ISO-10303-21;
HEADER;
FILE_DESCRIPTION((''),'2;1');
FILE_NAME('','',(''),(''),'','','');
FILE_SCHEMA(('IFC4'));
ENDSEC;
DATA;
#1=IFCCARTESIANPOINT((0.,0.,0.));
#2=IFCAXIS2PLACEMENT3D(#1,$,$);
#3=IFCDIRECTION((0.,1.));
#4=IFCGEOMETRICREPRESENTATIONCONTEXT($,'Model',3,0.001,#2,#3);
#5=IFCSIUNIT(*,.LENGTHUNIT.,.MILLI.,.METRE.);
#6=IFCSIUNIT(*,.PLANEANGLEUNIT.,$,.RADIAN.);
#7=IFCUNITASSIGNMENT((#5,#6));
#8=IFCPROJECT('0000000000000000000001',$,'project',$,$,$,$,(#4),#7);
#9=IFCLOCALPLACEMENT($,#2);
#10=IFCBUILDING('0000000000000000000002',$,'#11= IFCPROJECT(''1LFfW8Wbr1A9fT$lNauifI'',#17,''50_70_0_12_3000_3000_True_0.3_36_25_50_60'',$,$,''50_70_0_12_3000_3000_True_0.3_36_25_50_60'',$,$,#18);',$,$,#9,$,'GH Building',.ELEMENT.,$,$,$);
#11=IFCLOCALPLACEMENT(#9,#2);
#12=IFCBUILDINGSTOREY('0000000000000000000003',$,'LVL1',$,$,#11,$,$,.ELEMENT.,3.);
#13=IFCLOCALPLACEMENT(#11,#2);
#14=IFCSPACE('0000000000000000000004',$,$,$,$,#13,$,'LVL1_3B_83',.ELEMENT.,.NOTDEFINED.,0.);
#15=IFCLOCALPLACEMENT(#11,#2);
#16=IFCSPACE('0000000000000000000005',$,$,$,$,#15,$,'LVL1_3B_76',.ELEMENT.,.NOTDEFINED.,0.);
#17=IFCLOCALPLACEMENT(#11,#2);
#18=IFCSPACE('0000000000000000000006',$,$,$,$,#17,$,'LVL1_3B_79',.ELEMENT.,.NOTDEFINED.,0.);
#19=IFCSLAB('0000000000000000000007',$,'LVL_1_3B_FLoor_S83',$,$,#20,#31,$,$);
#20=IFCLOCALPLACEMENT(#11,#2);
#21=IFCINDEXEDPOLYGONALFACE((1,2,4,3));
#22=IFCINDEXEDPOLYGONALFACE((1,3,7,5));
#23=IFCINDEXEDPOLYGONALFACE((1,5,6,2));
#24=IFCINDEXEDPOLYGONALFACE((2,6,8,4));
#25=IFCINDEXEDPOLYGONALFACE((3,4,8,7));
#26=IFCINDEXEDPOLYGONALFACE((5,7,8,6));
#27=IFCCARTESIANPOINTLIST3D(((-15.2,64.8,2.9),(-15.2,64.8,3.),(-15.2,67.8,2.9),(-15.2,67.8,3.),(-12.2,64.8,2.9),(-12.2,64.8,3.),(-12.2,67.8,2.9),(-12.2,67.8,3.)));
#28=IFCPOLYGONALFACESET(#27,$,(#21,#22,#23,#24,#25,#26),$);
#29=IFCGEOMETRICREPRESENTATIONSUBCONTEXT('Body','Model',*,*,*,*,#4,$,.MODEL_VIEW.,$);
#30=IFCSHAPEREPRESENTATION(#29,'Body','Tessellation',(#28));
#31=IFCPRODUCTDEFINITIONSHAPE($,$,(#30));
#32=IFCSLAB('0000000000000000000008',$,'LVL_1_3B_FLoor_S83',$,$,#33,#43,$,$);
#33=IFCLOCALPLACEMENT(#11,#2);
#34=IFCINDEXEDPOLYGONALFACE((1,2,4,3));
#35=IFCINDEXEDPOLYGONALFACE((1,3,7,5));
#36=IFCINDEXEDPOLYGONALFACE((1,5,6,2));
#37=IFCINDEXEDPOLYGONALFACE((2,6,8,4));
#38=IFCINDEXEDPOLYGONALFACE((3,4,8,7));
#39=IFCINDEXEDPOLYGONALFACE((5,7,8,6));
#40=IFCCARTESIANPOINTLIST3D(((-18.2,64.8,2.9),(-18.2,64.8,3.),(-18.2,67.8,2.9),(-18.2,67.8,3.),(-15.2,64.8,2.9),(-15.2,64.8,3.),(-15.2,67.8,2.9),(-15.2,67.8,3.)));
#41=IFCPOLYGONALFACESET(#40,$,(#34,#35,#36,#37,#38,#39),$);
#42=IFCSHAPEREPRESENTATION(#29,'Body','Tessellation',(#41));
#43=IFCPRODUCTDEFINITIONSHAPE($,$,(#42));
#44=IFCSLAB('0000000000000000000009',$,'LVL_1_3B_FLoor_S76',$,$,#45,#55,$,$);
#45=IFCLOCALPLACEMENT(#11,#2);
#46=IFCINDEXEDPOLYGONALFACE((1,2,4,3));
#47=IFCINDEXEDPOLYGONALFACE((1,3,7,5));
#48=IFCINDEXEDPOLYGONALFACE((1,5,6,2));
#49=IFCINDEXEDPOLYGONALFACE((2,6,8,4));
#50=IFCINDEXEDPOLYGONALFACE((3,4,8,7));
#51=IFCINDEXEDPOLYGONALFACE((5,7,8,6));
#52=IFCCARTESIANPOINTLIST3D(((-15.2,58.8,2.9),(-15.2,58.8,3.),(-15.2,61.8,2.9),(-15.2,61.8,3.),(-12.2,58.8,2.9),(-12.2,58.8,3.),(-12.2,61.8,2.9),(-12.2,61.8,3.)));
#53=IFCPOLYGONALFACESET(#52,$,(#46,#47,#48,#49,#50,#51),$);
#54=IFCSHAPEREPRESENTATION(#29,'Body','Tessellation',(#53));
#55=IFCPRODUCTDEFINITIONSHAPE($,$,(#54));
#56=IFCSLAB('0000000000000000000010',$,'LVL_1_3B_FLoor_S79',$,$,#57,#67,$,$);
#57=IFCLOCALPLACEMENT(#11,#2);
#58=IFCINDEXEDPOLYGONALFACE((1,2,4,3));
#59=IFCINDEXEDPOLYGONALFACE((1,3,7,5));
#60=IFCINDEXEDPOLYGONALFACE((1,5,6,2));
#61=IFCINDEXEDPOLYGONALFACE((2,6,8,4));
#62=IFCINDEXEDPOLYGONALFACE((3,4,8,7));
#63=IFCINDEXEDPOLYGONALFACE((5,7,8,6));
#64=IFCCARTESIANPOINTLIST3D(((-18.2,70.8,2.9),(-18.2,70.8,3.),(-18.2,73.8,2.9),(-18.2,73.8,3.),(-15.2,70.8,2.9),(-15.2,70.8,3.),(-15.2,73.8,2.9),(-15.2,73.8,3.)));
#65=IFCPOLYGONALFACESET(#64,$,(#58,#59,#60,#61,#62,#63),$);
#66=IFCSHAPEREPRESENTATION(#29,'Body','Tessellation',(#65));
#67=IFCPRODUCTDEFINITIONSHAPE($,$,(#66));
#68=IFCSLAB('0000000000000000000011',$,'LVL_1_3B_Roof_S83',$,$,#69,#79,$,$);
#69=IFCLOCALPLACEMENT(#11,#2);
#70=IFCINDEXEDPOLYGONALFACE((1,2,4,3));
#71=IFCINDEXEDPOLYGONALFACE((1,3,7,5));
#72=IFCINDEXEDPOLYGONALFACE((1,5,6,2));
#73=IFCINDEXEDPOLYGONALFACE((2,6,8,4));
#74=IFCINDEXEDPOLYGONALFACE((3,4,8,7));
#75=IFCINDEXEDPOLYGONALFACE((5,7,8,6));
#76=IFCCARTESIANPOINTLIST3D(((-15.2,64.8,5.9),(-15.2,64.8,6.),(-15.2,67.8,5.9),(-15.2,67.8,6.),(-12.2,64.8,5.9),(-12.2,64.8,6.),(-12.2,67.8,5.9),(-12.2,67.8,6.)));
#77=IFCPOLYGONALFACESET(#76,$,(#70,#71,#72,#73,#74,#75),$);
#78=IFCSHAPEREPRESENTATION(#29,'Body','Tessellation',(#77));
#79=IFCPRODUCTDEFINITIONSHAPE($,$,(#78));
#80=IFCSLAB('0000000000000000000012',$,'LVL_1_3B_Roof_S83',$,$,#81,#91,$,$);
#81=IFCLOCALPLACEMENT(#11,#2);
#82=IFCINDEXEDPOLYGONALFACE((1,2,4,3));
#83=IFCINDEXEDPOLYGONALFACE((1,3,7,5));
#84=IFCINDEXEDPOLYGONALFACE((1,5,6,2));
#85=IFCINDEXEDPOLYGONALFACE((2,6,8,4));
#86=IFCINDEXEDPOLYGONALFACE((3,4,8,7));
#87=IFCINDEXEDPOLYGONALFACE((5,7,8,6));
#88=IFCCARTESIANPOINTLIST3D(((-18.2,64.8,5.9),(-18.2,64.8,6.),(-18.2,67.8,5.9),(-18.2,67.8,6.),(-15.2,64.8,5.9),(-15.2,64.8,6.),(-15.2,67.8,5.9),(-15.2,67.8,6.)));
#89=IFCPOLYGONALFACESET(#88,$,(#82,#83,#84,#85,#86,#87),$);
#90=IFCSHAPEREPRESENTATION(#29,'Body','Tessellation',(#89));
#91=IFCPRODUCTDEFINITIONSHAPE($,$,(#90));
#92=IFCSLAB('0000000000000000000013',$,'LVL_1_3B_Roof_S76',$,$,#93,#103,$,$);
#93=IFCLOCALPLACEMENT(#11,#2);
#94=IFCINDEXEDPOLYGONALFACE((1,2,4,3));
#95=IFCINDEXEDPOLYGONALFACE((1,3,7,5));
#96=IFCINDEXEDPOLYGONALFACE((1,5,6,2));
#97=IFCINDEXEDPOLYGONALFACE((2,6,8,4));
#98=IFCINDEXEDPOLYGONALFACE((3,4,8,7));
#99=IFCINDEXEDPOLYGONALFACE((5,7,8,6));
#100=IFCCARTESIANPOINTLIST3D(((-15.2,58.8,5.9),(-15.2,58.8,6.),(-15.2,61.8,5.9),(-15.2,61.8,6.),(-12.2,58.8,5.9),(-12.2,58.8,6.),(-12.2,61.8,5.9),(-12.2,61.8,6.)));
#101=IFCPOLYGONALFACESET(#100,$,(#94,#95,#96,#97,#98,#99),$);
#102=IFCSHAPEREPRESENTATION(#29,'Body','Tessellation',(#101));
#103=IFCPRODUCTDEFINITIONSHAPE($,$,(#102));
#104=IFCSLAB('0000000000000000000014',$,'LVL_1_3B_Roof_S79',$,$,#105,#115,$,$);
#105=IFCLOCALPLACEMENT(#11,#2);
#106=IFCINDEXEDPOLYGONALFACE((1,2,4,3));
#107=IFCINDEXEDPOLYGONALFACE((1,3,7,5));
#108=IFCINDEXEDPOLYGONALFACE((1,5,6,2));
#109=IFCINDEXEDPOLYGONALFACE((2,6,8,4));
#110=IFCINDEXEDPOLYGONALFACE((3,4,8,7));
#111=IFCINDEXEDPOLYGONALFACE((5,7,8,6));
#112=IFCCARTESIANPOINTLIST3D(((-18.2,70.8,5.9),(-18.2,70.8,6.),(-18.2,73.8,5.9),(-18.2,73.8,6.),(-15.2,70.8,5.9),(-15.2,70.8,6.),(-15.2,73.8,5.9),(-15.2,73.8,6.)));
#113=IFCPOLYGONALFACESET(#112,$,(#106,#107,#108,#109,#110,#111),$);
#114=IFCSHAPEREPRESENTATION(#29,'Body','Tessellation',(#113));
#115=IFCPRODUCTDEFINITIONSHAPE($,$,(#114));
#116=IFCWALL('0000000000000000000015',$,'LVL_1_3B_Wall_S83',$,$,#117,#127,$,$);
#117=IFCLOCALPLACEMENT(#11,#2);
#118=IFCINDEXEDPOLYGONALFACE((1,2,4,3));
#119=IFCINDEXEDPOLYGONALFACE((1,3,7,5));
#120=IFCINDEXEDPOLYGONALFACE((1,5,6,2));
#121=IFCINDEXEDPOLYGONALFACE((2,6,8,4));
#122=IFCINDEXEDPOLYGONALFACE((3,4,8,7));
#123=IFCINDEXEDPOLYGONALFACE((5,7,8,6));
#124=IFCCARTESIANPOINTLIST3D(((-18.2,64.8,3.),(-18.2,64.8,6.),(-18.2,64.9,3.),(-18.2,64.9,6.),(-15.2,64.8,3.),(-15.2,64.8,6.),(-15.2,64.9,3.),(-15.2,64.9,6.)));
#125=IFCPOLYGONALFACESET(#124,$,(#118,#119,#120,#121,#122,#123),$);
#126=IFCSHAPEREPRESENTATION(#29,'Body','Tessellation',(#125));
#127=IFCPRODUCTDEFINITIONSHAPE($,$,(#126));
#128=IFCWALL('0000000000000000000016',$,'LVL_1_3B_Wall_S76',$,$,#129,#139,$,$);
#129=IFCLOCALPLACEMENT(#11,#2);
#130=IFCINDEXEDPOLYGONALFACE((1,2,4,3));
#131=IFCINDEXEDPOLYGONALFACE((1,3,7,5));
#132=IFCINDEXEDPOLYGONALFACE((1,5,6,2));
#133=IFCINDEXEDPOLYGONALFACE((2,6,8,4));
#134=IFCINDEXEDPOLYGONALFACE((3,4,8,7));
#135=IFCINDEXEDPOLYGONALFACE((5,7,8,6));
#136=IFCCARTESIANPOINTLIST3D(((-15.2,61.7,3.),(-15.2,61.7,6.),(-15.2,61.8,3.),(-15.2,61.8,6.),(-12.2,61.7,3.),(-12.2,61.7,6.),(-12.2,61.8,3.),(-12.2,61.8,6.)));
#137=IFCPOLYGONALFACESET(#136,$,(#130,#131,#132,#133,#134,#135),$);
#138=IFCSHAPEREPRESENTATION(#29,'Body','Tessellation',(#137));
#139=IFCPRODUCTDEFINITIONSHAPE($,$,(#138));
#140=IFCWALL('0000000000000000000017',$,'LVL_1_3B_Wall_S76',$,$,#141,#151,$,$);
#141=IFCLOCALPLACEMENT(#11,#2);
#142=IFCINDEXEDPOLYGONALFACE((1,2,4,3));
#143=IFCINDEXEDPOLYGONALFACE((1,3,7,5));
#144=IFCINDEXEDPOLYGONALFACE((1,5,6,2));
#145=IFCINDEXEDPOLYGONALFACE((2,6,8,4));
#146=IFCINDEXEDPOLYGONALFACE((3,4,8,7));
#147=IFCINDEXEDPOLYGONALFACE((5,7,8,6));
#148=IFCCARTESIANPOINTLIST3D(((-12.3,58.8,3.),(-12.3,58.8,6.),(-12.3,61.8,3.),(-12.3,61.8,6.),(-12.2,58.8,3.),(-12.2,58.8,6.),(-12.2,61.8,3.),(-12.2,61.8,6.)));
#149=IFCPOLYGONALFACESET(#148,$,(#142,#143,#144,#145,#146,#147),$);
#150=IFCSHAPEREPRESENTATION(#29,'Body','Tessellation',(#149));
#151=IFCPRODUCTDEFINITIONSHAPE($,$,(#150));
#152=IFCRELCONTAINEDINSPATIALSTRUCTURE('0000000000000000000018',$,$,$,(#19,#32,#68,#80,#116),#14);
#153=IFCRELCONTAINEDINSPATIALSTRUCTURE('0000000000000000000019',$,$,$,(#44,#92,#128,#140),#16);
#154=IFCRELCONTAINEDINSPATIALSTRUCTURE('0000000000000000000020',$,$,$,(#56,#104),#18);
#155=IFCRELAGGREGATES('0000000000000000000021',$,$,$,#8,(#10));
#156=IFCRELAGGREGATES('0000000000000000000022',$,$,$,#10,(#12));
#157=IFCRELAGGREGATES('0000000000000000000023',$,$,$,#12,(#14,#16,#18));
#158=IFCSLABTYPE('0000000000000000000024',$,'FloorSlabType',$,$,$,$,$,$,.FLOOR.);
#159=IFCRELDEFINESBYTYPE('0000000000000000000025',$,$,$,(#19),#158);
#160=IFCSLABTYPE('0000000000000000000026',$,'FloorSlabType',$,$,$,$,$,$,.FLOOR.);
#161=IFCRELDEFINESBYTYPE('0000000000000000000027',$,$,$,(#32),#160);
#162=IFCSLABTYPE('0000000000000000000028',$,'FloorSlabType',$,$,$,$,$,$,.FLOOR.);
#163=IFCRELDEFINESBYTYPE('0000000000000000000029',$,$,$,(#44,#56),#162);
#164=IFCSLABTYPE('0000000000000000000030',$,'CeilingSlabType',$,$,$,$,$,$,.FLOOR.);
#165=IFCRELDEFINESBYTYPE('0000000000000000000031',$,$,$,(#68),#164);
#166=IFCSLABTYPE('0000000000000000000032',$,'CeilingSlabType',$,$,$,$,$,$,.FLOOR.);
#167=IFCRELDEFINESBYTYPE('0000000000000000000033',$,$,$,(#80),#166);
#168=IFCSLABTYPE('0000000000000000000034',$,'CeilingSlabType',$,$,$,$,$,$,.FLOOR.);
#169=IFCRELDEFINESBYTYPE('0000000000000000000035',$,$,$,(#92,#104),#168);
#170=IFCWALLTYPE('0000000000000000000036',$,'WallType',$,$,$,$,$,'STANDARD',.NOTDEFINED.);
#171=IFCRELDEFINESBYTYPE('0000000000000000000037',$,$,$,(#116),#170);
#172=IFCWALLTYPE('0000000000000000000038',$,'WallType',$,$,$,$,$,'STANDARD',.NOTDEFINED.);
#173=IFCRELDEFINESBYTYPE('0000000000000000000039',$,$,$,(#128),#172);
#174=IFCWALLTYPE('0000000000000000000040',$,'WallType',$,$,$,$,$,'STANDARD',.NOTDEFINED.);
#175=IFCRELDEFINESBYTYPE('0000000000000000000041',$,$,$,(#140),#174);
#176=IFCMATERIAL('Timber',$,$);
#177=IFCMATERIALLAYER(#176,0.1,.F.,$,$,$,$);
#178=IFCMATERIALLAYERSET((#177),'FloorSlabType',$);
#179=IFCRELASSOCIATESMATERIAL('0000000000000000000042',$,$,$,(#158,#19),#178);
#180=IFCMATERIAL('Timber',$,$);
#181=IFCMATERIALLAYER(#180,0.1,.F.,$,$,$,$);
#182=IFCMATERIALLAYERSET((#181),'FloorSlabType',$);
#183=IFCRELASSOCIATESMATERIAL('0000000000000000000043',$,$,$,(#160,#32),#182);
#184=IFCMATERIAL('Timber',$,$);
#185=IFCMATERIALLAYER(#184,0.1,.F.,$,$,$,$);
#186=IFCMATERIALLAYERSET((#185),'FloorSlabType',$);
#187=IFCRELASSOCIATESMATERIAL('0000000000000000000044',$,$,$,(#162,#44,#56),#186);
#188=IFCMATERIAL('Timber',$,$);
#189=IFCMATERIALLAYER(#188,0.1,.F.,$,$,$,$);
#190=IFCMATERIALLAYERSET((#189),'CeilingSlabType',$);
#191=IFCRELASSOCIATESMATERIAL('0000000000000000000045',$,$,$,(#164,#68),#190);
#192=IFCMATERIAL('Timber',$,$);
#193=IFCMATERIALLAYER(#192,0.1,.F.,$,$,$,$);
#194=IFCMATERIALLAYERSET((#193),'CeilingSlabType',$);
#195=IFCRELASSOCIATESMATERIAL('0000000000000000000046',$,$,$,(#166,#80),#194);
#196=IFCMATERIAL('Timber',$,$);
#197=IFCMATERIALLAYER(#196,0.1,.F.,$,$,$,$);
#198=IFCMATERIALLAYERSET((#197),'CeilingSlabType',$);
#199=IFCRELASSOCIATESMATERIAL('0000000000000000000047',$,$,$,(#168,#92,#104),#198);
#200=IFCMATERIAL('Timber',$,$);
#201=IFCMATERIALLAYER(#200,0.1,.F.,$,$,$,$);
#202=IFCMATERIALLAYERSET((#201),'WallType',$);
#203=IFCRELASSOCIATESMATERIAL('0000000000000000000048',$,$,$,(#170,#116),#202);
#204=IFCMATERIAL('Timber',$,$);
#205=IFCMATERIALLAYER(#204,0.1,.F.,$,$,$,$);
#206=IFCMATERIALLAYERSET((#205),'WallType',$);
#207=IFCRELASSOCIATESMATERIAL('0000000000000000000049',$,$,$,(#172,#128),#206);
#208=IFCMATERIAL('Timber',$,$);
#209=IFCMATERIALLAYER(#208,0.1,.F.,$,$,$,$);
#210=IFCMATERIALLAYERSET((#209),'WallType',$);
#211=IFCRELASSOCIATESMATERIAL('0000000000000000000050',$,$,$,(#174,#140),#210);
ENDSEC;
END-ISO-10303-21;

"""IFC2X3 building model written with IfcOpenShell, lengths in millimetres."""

from ifc_helpers import new_model, si_unit, direction, frame, frame_2d, origin, place, context, subcontext, project, spatial, rectangle, extrude, material, layer, layer_set, layer_usage, type_object, element, save


model = new_model("IFC2X3")

# Units and contexts
model_context = context("Model", 3, precision=0.001, world=origin(), true_north=direction((0.0, 1.0)))
body_context = subcontext(model_context, "Body", "Model", "MODEL_VIEW")
ifc_project = project(units=[si_unit("LENGTHUNIT", "METRE", prefix="MILLI"), si_unit("PLANEANGLEUNIT", "RADIAN")], contexts=[model_context])

# Building, storey
building_placement = place(None, origin())
building = spatial("IfcBuilding", under=ifc_project, at=building_placement, Name="#11= IFCPROJECT('1LFfW8Wbr1A9fT$lNauifI',#17,'50_70_0_12_3000_3000_True_0.3_36_25_50_60',$,$,'50_70_0_12_3000_3000_True_0.3_36_25_50_60',$,$,#18);", LongName="GH Building", CompositionType="ELEMENT")
storey_placement = place(building_placement, origin())
storey = spatial("IfcBuildingStorey", under=building, at=storey_placement, Name="LVL1", CompositionType="ELEMENT", Elevation=3.0)

# Shared definitions
space_1_placement = place(storey_placement, origin())
space_1 = spatial("IfcSpace", under=storey, at=space_1_placement, LongName="LVL1_3B_83", CompositionType="ELEMENT", InteriorOrExteriorSpace="NOTDEFINED", ElevationWithFlooring=0.0)

# Slabs
ifc_material_1 = material(Name="Timber")
ifc_layer_1 = layer(ifc_material_1, 0.1, ventilated=False)
ifc_layer_set_1 = layer_set([ifc_layer_1], Name="FloorSlabType")
ifc_layer_usage_1 = layer_usage(ifc_layer_set_1, "AXIS3", "NEGATIVE", -0.1)
slab_type_1 = type_object("IfcSlabType", Name="FloorSlabType", PredefinedType="FLOOR", material=ifc_layer_set_1)
slab_1_placement = place(space_1_placement, frame((-12.2, 67.8, 2.9), z_axis=(0.0, 0.0, 1.0), x_axis=(-1.0, 0.0, 0.0)))
element("IfcSlab", 1, at=slab_1_placement, inside=space_1, type_object=slab_type_1, material=ifc_layer_usage_1, Name="LVL_1_3B_FLoor_S83", context=body_context, shape_type="SweptSolid", body=[
    extrude(rectangle(XDim=3.0, YDim=3.0, at=frame_2d((1.5, 1.5))), origin(), (0.0, 0.0, 1.0), 0.1),
])
ifc_material_2 = material(Name="Timber")
ifc_layer_2 = layer(ifc_material_2, 0.1, ventilated=False)
ifc_layer_set_2 = layer_set([ifc_layer_2], Name="FloorSlabType")
ifc_layer_usage_2 = layer_usage(ifc_layer_set_2, "AXIS3", "NEGATIVE", -0.1)
slab_type_2 = type_object("IfcSlabType", Name="FloorSlabType", PredefinedType="FLOOR", material=ifc_layer_set_2)
slab_2_placement = place(space_1_placement, frame((-15.2, 67.8, 2.9), z_axis=(0.0, 0.0, 1.0), x_axis=(-1.0, 0.0, 0.0)))
element("IfcSlab", 2, at=slab_2_placement, inside=space_1, type_object=slab_type_2, material=ifc_layer_usage_2, Name="LVL_1_3B_FLoor_S83", context=body_context, shape_type="SweptSolid", body=[
    extrude(rectangle(XDim=3.0, YDim=3.0, at=frame_2d((1.5, 1.5))), origin(), (0.0, 0.0, 1.0), 0.1),
])

# Shared definitions
space_2_placement = place(storey_placement, origin())
space_2 = spatial("IfcSpace", under=storey, at=space_2_placement, LongName="LVL1_3B_76", CompositionType="ELEMENT", InteriorOrExteriorSpace="NOTDEFINED", ElevationWithFlooring=0.0)

# Slab
ifc_material_3 = material(Name="Timber")
ifc_layer_3 = layer(ifc_material_3, 0.1, ventilated=False)
ifc_layer_set_3 = layer_set([ifc_layer_3], Name="FloorSlabType")
ifc_layer_usage_3 = layer_usage(ifc_layer_set_3, "AXIS3", "NEGATIVE", -0.1)
slab_type_3 = type_object("IfcSlabType", Name="FloorSlabType", PredefinedType="FLOOR", material=ifc_layer_set_3)
slab_3_placement = place(space_2_placement, frame((-15.2, 61.8, 2.9), z_axis=(0.0, 0.0, 1.0), x_axis=(0.0, -1.0, 0.0)))
element("IfcSlab", 3, at=slab_3_placement, inside=space_2, type_object=slab_type_3, material=ifc_layer_usage_3, Name="LVL_1_3B_FLoor_S76", context=body_context, shape_type="SweptSolid", body=[
    extrude(rectangle(XDim=3.0, YDim=3.0, at=frame_2d((1.5, 1.5))), origin(), (0.0, 0.0, 1.0), 0.1),
])

# Shared definitions
space_3_placement = place(storey_placement, origin())
space_3 = spatial("IfcSpace", under=storey, at=space_3_placement, LongName="LVL1_3B_79", CompositionType="ELEMENT", InteriorOrExteriorSpace="NOTDEFINED", ElevationWithFlooring=0.0)

# Slabs
ifc_layer_usage_4 = layer_usage(ifc_layer_set_3, "AXIS3", "NEGATIVE", -0.1)
slab_4_placement = place(space_3_placement, frame((-15.2, 73.8, 2.9), z_axis=(0.0, 0.0, 1.0), x_axis=(-1.0, 0.0, 0.0)))
element("IfcSlab", 4, at=slab_4_placement, inside=space_3, type_object=slab_type_3, material=ifc_layer_usage_4, Name="LVL_1_3B_FLoor_S79", context=body_context, shape_type="SweptSolid", body=[
    extrude(rectangle(XDim=3.0, YDim=3.0, at=frame_2d((1.5, 1.5))), origin(), (0.0, 0.0, 1.0), 0.1),
])
ifc_material_4 = material(Name="Timber")
ifc_layer_4 = layer(ifc_material_4, 0.1, ventilated=False)
ifc_layer_set_4 = layer_set([ifc_layer_4], Name="CeilingSlabType")
ifc_layer_usage_5 = layer_usage(ifc_layer_set_4, "AXIS3", "NEGATIVE", -0.1)
slab_type_4 = type_object("IfcSlabType", Name="CeilingSlabType", PredefinedType="FLOOR", material=ifc_layer_set_4)
slab_5_placement = place(space_1_placement, frame((-12.2, 67.8, 5.9), z_axis=(0.0, 0.0, 1.0), x_axis=(-1.0, 0.0, 0.0)))
element("IfcSlab", 5, at=slab_5_placement, inside=space_1, type_object=slab_type_4, material=ifc_layer_usage_5, Name="LVL_1_3B_Roof_S83", context=body_context, shape_type="SweptSolid", body=[
    extrude(rectangle(XDim=3.0, YDim=3.0, at=frame_2d((1.5, 1.5))), origin(), (0.0, 0.0, 1.0), 0.1),
])
ifc_material_5 = material(Name="Timber")
ifc_layer_5 = layer(ifc_material_5, 0.1, ventilated=False)
ifc_layer_set_5 = layer_set([ifc_layer_5], Name="CeilingSlabType")
ifc_layer_usage_6 = layer_usage(ifc_layer_set_5, "AXIS3", "NEGATIVE", -0.1)
slab_type_5 = type_object("IfcSlabType", Name="CeilingSlabType", PredefinedType="FLOOR", material=ifc_layer_set_5)
slab_6_placement = place(space_1_placement, frame((-15.2, 67.8, 5.9), z_axis=(0.0, 0.0, 1.0), x_axis=(-1.0, 0.0, 0.0)))
element("IfcSlab", 6, at=slab_6_placement, inside=space_1, type_object=slab_type_5, material=ifc_layer_usage_6, Name="LVL_1_3B_Roof_S83", context=body_context, shape_type="SweptSolid", body=[
    extrude(rectangle(XDim=3.0, YDim=3.0, at=frame_2d((1.5, 1.5))), origin(), (0.0, 0.0, 1.0), 0.1),
])
ifc_material_6 = material(Name="Timber")
ifc_layer_6 = layer(ifc_material_6, 0.1, ventilated=False)
ifc_layer_set_6 = layer_set([ifc_layer_6], Name="CeilingSlabType")
ifc_layer_usage_7 = layer_usage(ifc_layer_set_6, "AXIS3", "NEGATIVE", -0.1)
slab_type_6 = type_object("IfcSlabType", Name="CeilingSlabType", PredefinedType="FLOOR", material=ifc_layer_set_6)
slab_7_placement = place(space_2_placement, frame((-15.2, 61.8, 5.9), z_axis=(0.0, 0.0, 1.0), x_axis=(0.0, -1.0, 0.0)))
element("IfcSlab", 7, at=slab_7_placement, inside=space_2, type_object=slab_type_6, material=ifc_layer_usage_7, Name="LVL_1_3B_Roof_S76", context=body_context, shape_type="SweptSolid", body=[
    extrude(rectangle(XDim=3.0, YDim=3.0, at=frame_2d((1.5, 1.5))), origin(), (0.0, 0.0, 1.0), 0.1),
])
ifc_layer_usage_8 = layer_usage(ifc_layer_set_6, "AXIS3", "NEGATIVE", -0.1)
slab_8_placement = place(space_3_placement, frame((-15.2, 73.8, 5.9), z_axis=(0.0, 0.0, 1.0), x_axis=(-1.0, 0.0, 0.0)))
element("IfcSlab", 8, at=slab_8_placement, inside=space_3, type_object=slab_type_6, material=ifc_layer_usage_8, Name="LVL_1_3B_Roof_S79", context=body_context, shape_type="SweptSolid", body=[
    extrude(rectangle(XDim=3.0, YDim=3.0, at=frame_2d((1.5, 1.5))), origin(), (0.0, 0.0, 1.0), 0.1),
])

# Walls
ifc_material_7 = material(Name="Timber")
ifc_layer_7 = layer(ifc_material_7, 0.1, ventilated=False)
ifc_layer_set_7 = layer_set([ifc_layer_7], Name="WallType")
ifc_layer_usage_9 = layer_usage(ifc_layer_set_7, "AXIS2", "NEGATIVE", 0.0)
wall_type_1 = type_object("IfcWallType", Name="WallType", ElementType="STANDARD", PredefinedType="NOTDEFINED", material=ifc_layer_set_7)
wall_1_placement = place(space_1_placement, frame((-15.2, 64.8, 3.0), z_axis=(0.0, 0.0, 1.0), x_axis=(-1.0, 0.0, 0.0)))
element("IfcWall", 9, at=wall_1_placement, inside=space_1, type_object=wall_type_1, material=ifc_layer_usage_9, Name="LVL_1_3B_Wall_S83", context=body_context, shape_type="SweptSolid", body=[
    extrude(rectangle(XDim=3.0, YDim=0.1, at=frame_2d((1.5, -0.1))), origin(), (0.0, 0.0, 1.0), 3.0),
])
ifc_material_8 = material(Name="Timber")
ifc_layer_8 = layer(ifc_material_8, 0.1, ventilated=False)
ifc_layer_set_8 = layer_set([ifc_layer_8], Name="WallType")
ifc_layer_usage_10 = layer_usage(ifc_layer_set_8, "AXIS2", "NEGATIVE", 0.0)
wall_type_2 = type_object("IfcWallType", Name="WallType", ElementType="STANDARD", PredefinedType="NOTDEFINED", material=ifc_layer_set_8)
wall_2_placement = place(space_2_placement, frame((-15.2, 61.8, 3.0)))
element("IfcWall", 10, at=wall_2_placement, inside=space_2, type_object=wall_type_2, material=ifc_layer_usage_10, Name="LVL_1_3B_Wall_S76", context=body_context, shape_type="SweptSolid", body=[
    extrude(rectangle(XDim=3.0, YDim=0.1, at=frame_2d((1.5, -0.1))), origin(), (0.0, 0.0, 1.0), 3.0),
])
ifc_material_9 = material(Name="Timber")
ifc_layer_9 = layer(ifc_material_9, 0.1, ventilated=False)
ifc_layer_set_9 = layer_set([ifc_layer_9], Name="WallType")
ifc_layer_usage_11 = layer_usage(ifc_layer_set_9, "AXIS2", "NEGATIVE", 0.0)
wall_type_3 = type_object("IfcWallType", Name="WallType", ElementType="STANDARD", PredefinedType="NOTDEFINED", material=ifc_layer_set_9)
wall_3_placement = place(space_2_placement, frame((-12.2, 61.8, 3.0), z_axis=(0.0, 0.0, 1.0), x_axis=(0.0, -1.0, 0.0)))
element("IfcWall", 11, at=wall_3_placement, inside=space_2, type_object=wall_type_3, material=ifc_layer_usage_11, Name="LVL_1_3B_Wall_S76", context=body_context, shape_type="SweptSolid", body=[
    extrude(rectangle(XDim=3.0, YDim=0.1, at=frame_2d((1.5, -0.1))), origin(), (0.0, 0.0, 1.0), 3.0),
])

save(model, "model.ifc")
